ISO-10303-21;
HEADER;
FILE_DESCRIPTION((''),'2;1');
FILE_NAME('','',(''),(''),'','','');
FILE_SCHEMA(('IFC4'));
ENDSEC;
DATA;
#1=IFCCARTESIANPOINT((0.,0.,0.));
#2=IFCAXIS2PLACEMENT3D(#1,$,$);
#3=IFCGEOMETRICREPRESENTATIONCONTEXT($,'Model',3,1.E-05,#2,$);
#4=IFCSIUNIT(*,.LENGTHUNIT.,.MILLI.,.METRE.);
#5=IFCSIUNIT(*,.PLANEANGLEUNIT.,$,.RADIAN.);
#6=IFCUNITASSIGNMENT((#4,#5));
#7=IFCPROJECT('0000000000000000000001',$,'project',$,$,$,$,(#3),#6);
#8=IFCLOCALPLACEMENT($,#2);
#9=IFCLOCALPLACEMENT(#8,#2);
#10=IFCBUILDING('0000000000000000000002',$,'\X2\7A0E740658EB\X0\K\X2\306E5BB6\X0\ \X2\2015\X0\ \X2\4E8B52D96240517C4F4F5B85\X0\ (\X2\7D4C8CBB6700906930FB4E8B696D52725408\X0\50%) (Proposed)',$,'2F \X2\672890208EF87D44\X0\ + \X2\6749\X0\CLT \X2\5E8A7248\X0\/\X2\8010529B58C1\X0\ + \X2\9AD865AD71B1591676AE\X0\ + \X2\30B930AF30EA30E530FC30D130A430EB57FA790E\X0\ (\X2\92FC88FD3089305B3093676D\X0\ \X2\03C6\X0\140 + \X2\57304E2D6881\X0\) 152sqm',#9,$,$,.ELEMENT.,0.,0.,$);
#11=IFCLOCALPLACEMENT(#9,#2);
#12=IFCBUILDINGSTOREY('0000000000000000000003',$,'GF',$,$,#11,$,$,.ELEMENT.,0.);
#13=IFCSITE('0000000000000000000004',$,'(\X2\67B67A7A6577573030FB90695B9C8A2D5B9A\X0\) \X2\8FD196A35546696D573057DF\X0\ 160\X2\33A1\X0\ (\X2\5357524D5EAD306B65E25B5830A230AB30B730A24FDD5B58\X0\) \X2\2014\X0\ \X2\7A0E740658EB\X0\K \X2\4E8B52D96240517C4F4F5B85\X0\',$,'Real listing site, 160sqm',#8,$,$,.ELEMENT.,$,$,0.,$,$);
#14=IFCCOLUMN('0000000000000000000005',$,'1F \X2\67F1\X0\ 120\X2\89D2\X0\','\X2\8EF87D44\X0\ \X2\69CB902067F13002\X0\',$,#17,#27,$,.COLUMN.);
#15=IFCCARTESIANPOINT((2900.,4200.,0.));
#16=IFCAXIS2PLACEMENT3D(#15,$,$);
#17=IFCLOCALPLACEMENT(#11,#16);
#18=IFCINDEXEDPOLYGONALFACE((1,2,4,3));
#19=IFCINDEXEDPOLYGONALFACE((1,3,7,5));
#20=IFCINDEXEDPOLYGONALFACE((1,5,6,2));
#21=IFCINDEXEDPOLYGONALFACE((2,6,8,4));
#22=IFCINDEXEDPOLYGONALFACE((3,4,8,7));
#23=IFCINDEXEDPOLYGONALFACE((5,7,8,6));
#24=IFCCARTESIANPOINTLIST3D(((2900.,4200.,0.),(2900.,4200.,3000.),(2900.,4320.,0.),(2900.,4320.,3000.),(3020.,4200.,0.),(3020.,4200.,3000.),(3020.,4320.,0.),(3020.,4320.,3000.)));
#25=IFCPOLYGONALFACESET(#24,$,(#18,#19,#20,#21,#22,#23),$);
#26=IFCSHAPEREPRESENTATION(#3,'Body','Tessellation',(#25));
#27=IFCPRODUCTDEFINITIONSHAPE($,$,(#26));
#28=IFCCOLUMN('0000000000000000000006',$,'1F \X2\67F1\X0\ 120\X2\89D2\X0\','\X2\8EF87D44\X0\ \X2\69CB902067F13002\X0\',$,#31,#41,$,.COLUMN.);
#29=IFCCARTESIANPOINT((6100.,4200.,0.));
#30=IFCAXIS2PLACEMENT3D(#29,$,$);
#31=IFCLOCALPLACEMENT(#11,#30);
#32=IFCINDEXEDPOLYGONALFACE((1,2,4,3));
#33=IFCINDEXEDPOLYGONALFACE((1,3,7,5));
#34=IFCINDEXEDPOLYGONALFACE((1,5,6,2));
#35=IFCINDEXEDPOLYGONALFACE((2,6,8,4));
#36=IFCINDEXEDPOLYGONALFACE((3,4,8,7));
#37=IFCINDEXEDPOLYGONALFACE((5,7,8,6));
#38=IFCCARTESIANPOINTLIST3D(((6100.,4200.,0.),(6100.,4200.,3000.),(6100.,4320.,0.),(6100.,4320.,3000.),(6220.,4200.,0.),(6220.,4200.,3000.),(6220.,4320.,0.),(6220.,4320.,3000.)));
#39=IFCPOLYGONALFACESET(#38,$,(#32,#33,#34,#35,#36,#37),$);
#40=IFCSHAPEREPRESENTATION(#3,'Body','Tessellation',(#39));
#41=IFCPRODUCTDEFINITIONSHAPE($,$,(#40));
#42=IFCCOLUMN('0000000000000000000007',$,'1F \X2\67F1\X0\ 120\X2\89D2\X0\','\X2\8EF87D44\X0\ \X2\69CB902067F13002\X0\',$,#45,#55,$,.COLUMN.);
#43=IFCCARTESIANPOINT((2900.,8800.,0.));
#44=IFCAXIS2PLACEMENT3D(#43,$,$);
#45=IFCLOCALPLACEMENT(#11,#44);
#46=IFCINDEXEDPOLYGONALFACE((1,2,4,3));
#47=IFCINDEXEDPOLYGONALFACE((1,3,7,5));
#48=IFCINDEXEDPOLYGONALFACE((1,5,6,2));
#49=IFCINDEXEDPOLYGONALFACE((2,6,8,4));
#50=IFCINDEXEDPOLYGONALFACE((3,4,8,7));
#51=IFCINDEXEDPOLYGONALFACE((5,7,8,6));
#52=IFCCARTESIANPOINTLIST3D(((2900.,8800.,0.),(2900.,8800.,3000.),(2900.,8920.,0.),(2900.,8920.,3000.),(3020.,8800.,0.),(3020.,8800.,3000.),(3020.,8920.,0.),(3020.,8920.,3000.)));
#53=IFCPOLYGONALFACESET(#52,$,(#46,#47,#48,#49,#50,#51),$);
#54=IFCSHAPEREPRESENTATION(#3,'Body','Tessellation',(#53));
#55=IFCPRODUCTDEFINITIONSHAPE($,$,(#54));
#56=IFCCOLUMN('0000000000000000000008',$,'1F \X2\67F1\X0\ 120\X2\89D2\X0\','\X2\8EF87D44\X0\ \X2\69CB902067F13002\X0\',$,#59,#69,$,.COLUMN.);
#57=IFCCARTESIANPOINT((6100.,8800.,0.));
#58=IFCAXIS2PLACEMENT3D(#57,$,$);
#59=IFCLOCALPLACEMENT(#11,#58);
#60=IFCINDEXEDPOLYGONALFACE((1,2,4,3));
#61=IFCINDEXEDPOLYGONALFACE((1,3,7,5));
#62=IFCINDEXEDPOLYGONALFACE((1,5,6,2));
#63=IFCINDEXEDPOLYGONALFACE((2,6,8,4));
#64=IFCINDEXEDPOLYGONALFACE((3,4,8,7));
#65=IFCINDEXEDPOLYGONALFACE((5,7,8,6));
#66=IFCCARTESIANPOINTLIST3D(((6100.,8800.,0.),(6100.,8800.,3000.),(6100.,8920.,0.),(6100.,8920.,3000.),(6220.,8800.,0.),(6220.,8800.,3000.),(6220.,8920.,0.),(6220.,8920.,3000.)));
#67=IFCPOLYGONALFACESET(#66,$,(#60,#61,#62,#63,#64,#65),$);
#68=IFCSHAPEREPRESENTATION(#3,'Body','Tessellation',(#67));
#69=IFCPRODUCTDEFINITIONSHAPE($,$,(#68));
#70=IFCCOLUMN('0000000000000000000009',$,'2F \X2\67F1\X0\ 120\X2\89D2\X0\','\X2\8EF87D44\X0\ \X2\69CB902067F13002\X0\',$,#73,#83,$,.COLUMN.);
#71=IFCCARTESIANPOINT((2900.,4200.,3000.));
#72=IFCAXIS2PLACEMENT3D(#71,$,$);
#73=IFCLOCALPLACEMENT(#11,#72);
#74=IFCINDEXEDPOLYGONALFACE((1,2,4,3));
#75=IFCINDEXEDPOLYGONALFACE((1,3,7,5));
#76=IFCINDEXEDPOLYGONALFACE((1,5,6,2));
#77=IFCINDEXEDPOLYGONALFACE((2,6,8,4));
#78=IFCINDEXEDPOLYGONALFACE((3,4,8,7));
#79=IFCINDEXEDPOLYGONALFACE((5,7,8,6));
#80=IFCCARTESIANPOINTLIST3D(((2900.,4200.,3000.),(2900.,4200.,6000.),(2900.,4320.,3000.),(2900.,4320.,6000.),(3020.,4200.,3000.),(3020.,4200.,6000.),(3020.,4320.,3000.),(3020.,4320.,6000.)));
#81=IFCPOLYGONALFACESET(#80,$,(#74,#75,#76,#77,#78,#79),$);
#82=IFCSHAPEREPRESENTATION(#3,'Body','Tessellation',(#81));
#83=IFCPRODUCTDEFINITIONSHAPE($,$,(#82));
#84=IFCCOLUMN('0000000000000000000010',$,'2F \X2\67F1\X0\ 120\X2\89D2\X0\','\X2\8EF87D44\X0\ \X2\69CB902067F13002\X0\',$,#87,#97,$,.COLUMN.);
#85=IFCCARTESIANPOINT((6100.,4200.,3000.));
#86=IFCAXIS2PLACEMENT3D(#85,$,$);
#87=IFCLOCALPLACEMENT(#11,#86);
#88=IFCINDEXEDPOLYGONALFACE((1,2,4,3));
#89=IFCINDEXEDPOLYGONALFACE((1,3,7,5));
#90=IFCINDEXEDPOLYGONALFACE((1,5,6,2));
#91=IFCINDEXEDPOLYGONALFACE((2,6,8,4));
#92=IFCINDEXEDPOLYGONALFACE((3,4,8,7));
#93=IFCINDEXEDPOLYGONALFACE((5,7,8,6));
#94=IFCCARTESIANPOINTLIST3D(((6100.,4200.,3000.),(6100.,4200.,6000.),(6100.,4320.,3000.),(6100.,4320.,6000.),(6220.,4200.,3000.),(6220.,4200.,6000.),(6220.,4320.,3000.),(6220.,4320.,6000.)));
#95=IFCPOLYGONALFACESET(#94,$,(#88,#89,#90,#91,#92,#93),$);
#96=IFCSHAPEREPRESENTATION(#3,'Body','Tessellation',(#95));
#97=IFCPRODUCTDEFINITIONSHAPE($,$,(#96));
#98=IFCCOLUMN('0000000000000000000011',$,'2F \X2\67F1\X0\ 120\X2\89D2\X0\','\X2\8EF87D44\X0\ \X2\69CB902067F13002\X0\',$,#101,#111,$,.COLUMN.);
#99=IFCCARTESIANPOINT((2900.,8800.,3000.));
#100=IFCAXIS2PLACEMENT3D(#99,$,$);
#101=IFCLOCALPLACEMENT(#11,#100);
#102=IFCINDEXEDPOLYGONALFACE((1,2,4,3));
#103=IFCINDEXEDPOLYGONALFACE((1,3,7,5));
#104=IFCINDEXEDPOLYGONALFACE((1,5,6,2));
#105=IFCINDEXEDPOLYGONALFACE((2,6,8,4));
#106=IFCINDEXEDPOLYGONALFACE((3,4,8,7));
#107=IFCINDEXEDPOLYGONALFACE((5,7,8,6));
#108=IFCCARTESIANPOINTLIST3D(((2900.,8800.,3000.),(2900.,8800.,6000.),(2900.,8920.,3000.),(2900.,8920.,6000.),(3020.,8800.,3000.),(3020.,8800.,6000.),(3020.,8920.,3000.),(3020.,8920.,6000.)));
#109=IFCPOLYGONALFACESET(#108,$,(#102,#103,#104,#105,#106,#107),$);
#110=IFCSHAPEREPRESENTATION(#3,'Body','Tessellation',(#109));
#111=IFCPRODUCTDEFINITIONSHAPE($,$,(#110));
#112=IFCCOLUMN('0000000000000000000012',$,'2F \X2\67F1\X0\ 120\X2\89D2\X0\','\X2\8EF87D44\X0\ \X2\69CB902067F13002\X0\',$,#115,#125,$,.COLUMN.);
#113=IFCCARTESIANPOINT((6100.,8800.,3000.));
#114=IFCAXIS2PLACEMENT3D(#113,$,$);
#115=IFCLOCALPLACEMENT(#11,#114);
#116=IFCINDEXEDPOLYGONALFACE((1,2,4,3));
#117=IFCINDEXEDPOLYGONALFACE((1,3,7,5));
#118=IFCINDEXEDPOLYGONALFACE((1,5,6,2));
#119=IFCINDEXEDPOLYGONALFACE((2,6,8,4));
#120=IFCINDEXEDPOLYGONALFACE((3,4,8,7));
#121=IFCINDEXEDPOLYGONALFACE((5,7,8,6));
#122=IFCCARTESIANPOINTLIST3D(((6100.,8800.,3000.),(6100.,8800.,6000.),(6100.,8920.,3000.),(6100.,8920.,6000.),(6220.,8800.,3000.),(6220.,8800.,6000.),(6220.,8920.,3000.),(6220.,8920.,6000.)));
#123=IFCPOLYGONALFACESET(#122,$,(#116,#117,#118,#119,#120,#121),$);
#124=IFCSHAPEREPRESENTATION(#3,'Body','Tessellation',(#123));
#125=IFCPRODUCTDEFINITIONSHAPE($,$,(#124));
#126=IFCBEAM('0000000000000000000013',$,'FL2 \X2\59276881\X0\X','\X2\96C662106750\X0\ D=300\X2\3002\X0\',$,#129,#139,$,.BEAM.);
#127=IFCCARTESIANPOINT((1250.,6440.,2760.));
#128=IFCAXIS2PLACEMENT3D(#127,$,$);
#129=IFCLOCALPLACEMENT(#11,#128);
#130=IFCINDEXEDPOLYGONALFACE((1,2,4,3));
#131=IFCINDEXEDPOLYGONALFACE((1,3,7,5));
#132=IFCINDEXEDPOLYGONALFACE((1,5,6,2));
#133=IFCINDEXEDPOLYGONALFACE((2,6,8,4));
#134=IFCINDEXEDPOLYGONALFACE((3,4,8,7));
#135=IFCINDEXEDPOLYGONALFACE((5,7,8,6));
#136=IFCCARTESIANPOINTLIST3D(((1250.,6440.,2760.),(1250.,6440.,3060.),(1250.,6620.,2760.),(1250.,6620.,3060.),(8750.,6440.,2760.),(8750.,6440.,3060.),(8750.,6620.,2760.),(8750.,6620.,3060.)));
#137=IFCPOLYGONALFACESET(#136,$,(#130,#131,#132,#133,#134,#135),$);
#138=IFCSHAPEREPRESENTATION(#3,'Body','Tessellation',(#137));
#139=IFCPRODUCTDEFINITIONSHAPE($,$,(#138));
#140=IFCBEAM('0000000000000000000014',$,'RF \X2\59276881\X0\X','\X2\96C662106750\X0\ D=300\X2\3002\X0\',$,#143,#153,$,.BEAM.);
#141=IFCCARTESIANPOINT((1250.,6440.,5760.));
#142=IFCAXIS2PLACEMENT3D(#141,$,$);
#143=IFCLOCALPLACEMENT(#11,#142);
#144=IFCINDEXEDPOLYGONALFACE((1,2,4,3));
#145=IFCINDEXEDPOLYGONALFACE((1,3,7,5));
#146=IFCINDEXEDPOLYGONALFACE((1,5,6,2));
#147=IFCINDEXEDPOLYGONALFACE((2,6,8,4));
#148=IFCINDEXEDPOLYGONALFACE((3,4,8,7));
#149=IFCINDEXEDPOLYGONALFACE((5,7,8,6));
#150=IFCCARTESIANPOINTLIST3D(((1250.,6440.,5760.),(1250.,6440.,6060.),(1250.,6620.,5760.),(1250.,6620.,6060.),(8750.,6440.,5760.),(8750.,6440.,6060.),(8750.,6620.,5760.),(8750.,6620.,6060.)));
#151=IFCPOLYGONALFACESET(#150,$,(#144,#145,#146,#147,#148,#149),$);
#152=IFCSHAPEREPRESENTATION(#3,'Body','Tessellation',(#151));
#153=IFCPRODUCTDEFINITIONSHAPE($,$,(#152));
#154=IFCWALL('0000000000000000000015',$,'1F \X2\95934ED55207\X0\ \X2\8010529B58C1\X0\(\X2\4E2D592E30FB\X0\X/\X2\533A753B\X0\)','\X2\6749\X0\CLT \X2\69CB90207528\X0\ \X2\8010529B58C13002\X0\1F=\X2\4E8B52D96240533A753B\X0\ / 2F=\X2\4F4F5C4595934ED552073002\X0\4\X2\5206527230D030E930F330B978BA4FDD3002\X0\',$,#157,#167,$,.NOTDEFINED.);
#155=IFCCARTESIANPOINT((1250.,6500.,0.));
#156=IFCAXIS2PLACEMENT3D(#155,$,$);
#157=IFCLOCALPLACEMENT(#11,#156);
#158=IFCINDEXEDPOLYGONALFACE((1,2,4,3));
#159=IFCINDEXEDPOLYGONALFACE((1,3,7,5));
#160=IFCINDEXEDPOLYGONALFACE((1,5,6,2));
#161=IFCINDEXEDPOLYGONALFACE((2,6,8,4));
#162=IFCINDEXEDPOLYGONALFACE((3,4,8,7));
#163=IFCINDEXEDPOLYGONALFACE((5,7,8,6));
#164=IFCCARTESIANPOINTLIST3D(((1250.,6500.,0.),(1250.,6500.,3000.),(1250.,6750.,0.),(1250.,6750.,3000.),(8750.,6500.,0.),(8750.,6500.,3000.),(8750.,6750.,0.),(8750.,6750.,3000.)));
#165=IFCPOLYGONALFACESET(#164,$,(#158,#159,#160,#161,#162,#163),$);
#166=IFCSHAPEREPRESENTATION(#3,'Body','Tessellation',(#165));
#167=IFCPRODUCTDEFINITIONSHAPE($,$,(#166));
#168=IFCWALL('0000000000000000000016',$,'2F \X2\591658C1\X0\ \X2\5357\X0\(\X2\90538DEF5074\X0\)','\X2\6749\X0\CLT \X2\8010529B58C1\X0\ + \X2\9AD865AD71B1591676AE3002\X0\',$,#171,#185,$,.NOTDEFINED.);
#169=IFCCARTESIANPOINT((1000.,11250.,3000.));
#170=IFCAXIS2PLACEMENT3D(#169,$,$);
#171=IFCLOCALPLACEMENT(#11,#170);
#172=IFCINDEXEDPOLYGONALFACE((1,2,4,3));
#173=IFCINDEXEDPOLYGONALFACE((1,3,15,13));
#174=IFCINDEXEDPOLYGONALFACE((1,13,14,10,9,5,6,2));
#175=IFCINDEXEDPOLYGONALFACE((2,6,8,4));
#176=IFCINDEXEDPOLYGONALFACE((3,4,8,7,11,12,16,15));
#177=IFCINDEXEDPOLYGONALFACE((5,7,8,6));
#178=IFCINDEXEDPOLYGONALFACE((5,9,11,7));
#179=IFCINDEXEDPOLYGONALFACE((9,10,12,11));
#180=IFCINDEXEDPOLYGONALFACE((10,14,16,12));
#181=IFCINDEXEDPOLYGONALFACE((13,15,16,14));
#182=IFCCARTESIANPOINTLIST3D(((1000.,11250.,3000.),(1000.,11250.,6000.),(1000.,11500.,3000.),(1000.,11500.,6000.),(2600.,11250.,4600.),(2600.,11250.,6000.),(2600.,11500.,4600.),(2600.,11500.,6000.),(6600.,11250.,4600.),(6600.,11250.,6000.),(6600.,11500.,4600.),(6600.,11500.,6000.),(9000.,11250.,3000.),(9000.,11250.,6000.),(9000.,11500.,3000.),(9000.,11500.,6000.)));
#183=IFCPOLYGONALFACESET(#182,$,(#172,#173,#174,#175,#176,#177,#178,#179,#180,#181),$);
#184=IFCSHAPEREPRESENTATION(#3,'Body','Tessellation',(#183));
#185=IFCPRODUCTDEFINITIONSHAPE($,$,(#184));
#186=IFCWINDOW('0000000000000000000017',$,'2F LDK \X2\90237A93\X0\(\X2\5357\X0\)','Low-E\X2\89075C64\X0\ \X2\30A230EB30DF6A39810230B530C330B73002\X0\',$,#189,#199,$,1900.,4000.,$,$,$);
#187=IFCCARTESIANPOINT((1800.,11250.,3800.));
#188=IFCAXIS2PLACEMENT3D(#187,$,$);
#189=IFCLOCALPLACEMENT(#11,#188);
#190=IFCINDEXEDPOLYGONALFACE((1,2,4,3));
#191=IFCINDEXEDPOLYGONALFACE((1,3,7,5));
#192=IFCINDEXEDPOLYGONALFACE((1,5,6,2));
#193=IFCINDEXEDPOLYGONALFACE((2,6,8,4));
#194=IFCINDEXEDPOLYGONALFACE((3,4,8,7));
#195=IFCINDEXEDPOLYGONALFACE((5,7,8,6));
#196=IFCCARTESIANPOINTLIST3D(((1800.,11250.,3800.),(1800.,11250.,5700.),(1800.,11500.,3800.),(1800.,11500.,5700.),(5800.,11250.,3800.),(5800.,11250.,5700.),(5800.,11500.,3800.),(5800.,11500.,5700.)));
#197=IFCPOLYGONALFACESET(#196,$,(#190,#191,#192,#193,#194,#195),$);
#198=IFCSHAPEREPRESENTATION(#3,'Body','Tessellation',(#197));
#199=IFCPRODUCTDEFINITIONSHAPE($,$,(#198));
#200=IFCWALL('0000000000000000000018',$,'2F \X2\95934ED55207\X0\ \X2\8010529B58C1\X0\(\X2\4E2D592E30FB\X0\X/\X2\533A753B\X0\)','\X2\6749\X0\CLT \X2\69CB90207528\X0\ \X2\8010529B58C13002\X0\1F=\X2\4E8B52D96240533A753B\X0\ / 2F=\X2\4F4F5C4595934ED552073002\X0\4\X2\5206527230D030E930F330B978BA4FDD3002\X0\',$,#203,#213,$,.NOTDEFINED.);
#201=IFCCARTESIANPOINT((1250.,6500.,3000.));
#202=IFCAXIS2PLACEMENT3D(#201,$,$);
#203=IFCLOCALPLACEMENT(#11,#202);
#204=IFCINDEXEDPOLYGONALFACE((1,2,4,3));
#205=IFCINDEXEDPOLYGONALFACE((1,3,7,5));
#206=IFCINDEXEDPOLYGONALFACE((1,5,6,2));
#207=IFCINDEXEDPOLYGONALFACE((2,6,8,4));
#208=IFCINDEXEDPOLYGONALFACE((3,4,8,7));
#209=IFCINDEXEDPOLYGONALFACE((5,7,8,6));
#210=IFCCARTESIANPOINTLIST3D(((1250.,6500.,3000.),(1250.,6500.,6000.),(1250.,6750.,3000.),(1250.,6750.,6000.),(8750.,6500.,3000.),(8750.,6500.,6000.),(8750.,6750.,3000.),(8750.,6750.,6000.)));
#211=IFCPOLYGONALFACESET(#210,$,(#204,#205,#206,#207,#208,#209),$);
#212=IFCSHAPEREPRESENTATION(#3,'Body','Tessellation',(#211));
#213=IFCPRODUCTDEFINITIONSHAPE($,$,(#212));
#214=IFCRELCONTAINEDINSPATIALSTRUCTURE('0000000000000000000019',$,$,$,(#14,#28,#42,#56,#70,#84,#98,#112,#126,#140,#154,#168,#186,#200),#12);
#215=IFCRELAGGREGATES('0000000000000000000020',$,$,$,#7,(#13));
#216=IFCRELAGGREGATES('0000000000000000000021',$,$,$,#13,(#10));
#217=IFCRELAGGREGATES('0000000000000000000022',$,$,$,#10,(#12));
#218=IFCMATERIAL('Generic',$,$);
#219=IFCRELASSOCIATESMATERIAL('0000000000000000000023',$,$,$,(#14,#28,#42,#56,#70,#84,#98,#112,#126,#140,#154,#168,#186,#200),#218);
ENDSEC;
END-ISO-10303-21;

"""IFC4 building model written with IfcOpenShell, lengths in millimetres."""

from ifc_helpers import new_model, si_unit, frame, frame_2d, origin, place, context, project, spatial, rectangle, extrude, material, element, fill, save


model = new_model("IFC4")

# Units and contexts
model_context = context("Model", 3, precision=1e-05, world=origin())
ifc_project = project(units=[si_unit("LENGTHUNIT", "METRE", prefix="MILLI"), si_unit("PLANEANGLEUNIT", "RADIAN")], contexts=[model_context])

# Site, building, storey
site_placement = place(None, origin())
site = spatial("IfcSite", under=ifc_project, at=site_placement, Name="(架空敷地・適宜設定) 近隣商業地域 160㎡ (南前庭に既存アカシア保存) — 税理士K 事務所兼住宅", ObjectType="Real listing site, 160sqm", CompositionType="ELEMENT", RefElevation=0.0)
building_placement = place(site_placement, origin())
building = spatial("IfcBuilding", under=site, at=building_placement, Name="税理士Kの家 ― 事務所兼住宅 (経費最適・事業割合50%) (Proposed)", ObjectType="2F 木造軸組 + 杉CLT 床版/耐力壁 + 高断熱外皮 + スクリューパイル基礎 (鋼製らせん杭 φ140 + 地中梁) 152sqm", CompositionType="ELEMENT", ElevationOfRefHeight=0.0, ElevationOfTerrain=0.0)
storey_placement = place(building_placement, origin())
storey = spatial("IfcBuildingStorey", under=building, at=storey_placement, Name="GF", CompositionType="ELEMENT", Elevation=0.0)

# Columns
ifc_material = material(Name="Generic")
column_1_placement = place(storey_placement, frame((2900.0, 4200.0, 0.0)))
element("IfcColumn", 1, at=column_1_placement, inside=storey, material=ifc_material, Name="1F 柱 120角", Description="軸組 構造柱。", PredefinedType="COLUMN", context=model_context, shape_type="SweptSolid", body=[
    extrude(rectangle(XDim=120.0, YDim=120.0, at=frame_2d((60.0, 60.0))), frame((2900.0, 4200.0, 0.0)), (0.0, 0.0, 1.0), 3000.0),
])
column_2_placement = place(storey_placement, frame((6100.0, 4200.0, 0.0)))
element("IfcColumn", 2, at=column_2_placement, inside=storey, material=ifc_material, Name="1F 柱 120角", Description="軸組 構造柱。", PredefinedType="COLUMN", context=model_context, shape_type="SweptSolid", body=[
    extrude(rectangle(XDim=120.0, YDim=120.0, at=frame_2d((60.0, 60.0))), frame((6100.0, 4200.0, 0.0)), (0.0, 0.0, 1.0), 3000.0),
])
column_3_placement = place(storey_placement, frame((2900.0, 8800.0, 0.0)))
element("IfcColumn", 3, at=column_3_placement, inside=storey, material=ifc_material, Name="1F 柱 120角", Description="軸組 構造柱。", PredefinedType="COLUMN", context=model_context, shape_type="SweptSolid", body=[
    extrude(rectangle(XDim=120.0, YDim=120.0, at=frame_2d((60.0, 60.0))), frame((2900.0, 8800.0, 0.0)), (0.0, 0.0, 1.0), 3000.0),
])
column_4_placement = place(storey_placement, frame((6100.0, 8800.0, 0.0)))
element("IfcColumn", 4, at=column_4_placement, inside=storey, material=ifc_material, Name="1F 柱 120角", Description="軸組 構造柱。", PredefinedType="COLUMN", context=model_context, shape_type="SweptSolid", body=[
    extrude(rectangle(XDim=120.0, YDim=120.0, at=frame_2d((60.0, 60.0))), frame((6100.0, 8800.0, 0.0)), (0.0, 0.0, 1.0), 3000.0),
])
column_5_placement = place(storey_placement, frame((2900.0, 4200.0, 3000.0)))
element("IfcColumn", 5, at=column_5_placement, inside=storey, material=ifc_material, Name="2F 柱 120角", Description="軸組 構造柱。", PredefinedType="COLUMN", context=model_context, shape_type="SweptSolid", body=[
    extrude(rectangle(XDim=120.0, YDim=120.0, at=frame_2d((60.0, 60.0))), frame((2900.0, 4200.0, 3000.0)), (0.0, 0.0, 1.0), 3000.0),
])
column_6_placement = place(storey_placement, frame((6100.0, 4200.0, 3000.0)))
element("IfcColumn", 6, at=column_6_placement, inside=storey, material=ifc_material, Name="2F 柱 120角", Description="軸組 構造柱。", PredefinedType="COLUMN", context=model_context, shape_type="SweptSolid", body=[
    extrude(rectangle(XDim=120.0, YDim=120.0, at=frame_2d((60.0, 60.0))), frame((6100.0, 4200.0, 3000.0)), (0.0, 0.0, 1.0), 3000.0),
])
column_7_placement = place(storey_placement, frame((2900.0, 8800.0, 3000.0)))
element("IfcColumn", 7, at=column_7_placement, inside=storey, material=ifc_material, Name="2F 柱 120角", Description="軸組 構造柱。", PredefinedType="COLUMN", context=model_context, shape_type="SweptSolid", body=[
    extrude(rectangle(XDim=120.0, YDim=120.0, at=frame_2d((60.0, 60.0))), frame((2900.0, 8800.0, 3000.0)), (0.0, 0.0, 1.0), 3000.0),
])
column_8_placement = place(storey_placement, frame((6100.0, 8800.0, 3000.0)))
element("IfcColumn", 8, at=column_8_placement, inside=storey, material=ifc_material, Name="2F 柱 120角", Description="軸組 構造柱。", PredefinedType="COLUMN", context=model_context, shape_type="SweptSolid", body=[
    extrude(rectangle(XDim=120.0, YDim=120.0, at=frame_2d((60.0, 60.0))), frame((6100.0, 8800.0, 3000.0)), (0.0, 0.0, 1.0), 3000.0),
])

# Beams
beam_1_placement = place(storey_placement, frame((1250.0, 6440.0, 2760.0)))
element("IfcBeam", 9, at=beam_1_placement, inside=storey, material=ifc_material, Name="FL2 大梁X", Description="集成材 D=300。", PredefinedType="BEAM", context=model_context, shape_type="SweptSolid", body=[
    extrude(rectangle(XDim=7500.0, YDim=180.0, at=frame_2d((3750.0, 90.0))), frame((1250.0, 6440.0, 2760.0)), (0.0, 0.0, 1.0), 300.0),
])
beam_2_placement = place(storey_placement, frame((1250.0, 6440.0, 5760.0)))
element("IfcBeam", 10, at=beam_2_placement, inside=storey, material=ifc_material, Name="RF 大梁X", Description="集成材 D=300。", PredefinedType="BEAM", context=model_context, shape_type="SweptSolid", body=[
    extrude(rectangle(XDim=7500.0, YDim=180.0, at=frame_2d((3750.0, 90.0))), frame((1250.0, 6440.0, 5760.0)), (0.0, 0.0, 1.0), 300.0),
])

# Wall
wall_1_placement = place(storey_placement, frame((1250.0, 6500.0, 0.0)))
element("IfcWall", 11, at=wall_1_placement, inside=storey, material=ifc_material, Name="1F 間仕切 耐力壁(中央・X/区画)", Description="杉CLT 構造用 耐力壁。1F=事務所区画 / 2F=住居間仕切。4分割バランス確保。", PredefinedType="NOTDEFINED", context=model_context, shape_type="SweptSolid", body=[
    extrude(rectangle(XDim=7500.0, YDim=250.0, at=frame_2d((3750.0, 125.0))), frame((1250.0, 6500.0, 0.0)), (0.0, 0.0, 1.0), 3000.0),
])

# Wall, opening, window
wall_2_placement = place(storey_placement, frame((1000.0, 11250.0, 3000.0)))
wall_2 = element("IfcWall", 12, at=wall_2_placement, inside=storey, material=ifc_material, Name="2F 外壁 南(道路側)", Description="杉CLT 耐力壁 + 高断熱外皮。", PredefinedType="NOTDEFINED", context=model_context, shape_type="SweptSolid", body=[
    extrude(rectangle(XDim=8000.0, YDim=250.0, at=frame_2d((4000.0, 125.0))), frame((1000.0, 11250.0, 3000.0)), (0.0, 0.0, 1.0), 3000.0),
])
opening_1_placement = place(storey_placement, frame((1800.0, 11250.0, 3800.0)))
opening_1 = element("IfcOpeningElement", 13, at=opening_1_placement, cuts=wall_2, PredefinedType="NOTDEFINED", context=model_context, shape_type="SweptSolid", body=[
    extrude(rectangle(XDim=4000.0, YDim=250.0, at=frame_2d((2000.0, 125.0))), frame((1800.0, 11250.0, 3800.0)), (0.0, 0.0, 1.0), 1900.0),
])
window_1_placement = place(storey_placement, frame((1800.0, 11250.0, 3800.0)))
window_1 = element("IfcWindow", 14, at=window_1_placement, inside=storey, material=ifc_material, Name="2F LDK 連窓(南)", Description="Low-E複層 アルミ樹脂サッシ。", OverallHeight=1900.0, OverallWidth=4000.0, context=model_context, shape_type="SweptSolid", body=[
    extrude(rectangle(XDim=4000.0, YDim=250.0, at=frame_2d((2000.0, 125.0))), frame((1800.0, 11250.0, 3800.0)), (0.0, 0.0, 1.0), 1900.0),
])
fill(opening_1, window_1)

# Wall
wall_3_placement = place(storey_placement, frame((1250.0, 6500.0, 3000.0)))
element("IfcWall", 15, at=wall_3_placement, inside=storey, material=ifc_material, Name="2F 間仕切 耐力壁(中央・X/区画)", Description="杉CLT 構造用 耐力壁。1F=事務所区画 / 2F=住居間仕切。4分割バランス確保。", PredefinedType="NOTDEFINED", context=model_context, shape_type="SweptSolid", body=[
    extrude(rectangle(XDim=7500.0, YDim=250.0, at=frame_2d((3750.0, 125.0))), frame((1250.0, 6500.0, 3000.0)), (0.0, 0.0, 1.0), 3000.0),
])

save(model, "model.ifc")
